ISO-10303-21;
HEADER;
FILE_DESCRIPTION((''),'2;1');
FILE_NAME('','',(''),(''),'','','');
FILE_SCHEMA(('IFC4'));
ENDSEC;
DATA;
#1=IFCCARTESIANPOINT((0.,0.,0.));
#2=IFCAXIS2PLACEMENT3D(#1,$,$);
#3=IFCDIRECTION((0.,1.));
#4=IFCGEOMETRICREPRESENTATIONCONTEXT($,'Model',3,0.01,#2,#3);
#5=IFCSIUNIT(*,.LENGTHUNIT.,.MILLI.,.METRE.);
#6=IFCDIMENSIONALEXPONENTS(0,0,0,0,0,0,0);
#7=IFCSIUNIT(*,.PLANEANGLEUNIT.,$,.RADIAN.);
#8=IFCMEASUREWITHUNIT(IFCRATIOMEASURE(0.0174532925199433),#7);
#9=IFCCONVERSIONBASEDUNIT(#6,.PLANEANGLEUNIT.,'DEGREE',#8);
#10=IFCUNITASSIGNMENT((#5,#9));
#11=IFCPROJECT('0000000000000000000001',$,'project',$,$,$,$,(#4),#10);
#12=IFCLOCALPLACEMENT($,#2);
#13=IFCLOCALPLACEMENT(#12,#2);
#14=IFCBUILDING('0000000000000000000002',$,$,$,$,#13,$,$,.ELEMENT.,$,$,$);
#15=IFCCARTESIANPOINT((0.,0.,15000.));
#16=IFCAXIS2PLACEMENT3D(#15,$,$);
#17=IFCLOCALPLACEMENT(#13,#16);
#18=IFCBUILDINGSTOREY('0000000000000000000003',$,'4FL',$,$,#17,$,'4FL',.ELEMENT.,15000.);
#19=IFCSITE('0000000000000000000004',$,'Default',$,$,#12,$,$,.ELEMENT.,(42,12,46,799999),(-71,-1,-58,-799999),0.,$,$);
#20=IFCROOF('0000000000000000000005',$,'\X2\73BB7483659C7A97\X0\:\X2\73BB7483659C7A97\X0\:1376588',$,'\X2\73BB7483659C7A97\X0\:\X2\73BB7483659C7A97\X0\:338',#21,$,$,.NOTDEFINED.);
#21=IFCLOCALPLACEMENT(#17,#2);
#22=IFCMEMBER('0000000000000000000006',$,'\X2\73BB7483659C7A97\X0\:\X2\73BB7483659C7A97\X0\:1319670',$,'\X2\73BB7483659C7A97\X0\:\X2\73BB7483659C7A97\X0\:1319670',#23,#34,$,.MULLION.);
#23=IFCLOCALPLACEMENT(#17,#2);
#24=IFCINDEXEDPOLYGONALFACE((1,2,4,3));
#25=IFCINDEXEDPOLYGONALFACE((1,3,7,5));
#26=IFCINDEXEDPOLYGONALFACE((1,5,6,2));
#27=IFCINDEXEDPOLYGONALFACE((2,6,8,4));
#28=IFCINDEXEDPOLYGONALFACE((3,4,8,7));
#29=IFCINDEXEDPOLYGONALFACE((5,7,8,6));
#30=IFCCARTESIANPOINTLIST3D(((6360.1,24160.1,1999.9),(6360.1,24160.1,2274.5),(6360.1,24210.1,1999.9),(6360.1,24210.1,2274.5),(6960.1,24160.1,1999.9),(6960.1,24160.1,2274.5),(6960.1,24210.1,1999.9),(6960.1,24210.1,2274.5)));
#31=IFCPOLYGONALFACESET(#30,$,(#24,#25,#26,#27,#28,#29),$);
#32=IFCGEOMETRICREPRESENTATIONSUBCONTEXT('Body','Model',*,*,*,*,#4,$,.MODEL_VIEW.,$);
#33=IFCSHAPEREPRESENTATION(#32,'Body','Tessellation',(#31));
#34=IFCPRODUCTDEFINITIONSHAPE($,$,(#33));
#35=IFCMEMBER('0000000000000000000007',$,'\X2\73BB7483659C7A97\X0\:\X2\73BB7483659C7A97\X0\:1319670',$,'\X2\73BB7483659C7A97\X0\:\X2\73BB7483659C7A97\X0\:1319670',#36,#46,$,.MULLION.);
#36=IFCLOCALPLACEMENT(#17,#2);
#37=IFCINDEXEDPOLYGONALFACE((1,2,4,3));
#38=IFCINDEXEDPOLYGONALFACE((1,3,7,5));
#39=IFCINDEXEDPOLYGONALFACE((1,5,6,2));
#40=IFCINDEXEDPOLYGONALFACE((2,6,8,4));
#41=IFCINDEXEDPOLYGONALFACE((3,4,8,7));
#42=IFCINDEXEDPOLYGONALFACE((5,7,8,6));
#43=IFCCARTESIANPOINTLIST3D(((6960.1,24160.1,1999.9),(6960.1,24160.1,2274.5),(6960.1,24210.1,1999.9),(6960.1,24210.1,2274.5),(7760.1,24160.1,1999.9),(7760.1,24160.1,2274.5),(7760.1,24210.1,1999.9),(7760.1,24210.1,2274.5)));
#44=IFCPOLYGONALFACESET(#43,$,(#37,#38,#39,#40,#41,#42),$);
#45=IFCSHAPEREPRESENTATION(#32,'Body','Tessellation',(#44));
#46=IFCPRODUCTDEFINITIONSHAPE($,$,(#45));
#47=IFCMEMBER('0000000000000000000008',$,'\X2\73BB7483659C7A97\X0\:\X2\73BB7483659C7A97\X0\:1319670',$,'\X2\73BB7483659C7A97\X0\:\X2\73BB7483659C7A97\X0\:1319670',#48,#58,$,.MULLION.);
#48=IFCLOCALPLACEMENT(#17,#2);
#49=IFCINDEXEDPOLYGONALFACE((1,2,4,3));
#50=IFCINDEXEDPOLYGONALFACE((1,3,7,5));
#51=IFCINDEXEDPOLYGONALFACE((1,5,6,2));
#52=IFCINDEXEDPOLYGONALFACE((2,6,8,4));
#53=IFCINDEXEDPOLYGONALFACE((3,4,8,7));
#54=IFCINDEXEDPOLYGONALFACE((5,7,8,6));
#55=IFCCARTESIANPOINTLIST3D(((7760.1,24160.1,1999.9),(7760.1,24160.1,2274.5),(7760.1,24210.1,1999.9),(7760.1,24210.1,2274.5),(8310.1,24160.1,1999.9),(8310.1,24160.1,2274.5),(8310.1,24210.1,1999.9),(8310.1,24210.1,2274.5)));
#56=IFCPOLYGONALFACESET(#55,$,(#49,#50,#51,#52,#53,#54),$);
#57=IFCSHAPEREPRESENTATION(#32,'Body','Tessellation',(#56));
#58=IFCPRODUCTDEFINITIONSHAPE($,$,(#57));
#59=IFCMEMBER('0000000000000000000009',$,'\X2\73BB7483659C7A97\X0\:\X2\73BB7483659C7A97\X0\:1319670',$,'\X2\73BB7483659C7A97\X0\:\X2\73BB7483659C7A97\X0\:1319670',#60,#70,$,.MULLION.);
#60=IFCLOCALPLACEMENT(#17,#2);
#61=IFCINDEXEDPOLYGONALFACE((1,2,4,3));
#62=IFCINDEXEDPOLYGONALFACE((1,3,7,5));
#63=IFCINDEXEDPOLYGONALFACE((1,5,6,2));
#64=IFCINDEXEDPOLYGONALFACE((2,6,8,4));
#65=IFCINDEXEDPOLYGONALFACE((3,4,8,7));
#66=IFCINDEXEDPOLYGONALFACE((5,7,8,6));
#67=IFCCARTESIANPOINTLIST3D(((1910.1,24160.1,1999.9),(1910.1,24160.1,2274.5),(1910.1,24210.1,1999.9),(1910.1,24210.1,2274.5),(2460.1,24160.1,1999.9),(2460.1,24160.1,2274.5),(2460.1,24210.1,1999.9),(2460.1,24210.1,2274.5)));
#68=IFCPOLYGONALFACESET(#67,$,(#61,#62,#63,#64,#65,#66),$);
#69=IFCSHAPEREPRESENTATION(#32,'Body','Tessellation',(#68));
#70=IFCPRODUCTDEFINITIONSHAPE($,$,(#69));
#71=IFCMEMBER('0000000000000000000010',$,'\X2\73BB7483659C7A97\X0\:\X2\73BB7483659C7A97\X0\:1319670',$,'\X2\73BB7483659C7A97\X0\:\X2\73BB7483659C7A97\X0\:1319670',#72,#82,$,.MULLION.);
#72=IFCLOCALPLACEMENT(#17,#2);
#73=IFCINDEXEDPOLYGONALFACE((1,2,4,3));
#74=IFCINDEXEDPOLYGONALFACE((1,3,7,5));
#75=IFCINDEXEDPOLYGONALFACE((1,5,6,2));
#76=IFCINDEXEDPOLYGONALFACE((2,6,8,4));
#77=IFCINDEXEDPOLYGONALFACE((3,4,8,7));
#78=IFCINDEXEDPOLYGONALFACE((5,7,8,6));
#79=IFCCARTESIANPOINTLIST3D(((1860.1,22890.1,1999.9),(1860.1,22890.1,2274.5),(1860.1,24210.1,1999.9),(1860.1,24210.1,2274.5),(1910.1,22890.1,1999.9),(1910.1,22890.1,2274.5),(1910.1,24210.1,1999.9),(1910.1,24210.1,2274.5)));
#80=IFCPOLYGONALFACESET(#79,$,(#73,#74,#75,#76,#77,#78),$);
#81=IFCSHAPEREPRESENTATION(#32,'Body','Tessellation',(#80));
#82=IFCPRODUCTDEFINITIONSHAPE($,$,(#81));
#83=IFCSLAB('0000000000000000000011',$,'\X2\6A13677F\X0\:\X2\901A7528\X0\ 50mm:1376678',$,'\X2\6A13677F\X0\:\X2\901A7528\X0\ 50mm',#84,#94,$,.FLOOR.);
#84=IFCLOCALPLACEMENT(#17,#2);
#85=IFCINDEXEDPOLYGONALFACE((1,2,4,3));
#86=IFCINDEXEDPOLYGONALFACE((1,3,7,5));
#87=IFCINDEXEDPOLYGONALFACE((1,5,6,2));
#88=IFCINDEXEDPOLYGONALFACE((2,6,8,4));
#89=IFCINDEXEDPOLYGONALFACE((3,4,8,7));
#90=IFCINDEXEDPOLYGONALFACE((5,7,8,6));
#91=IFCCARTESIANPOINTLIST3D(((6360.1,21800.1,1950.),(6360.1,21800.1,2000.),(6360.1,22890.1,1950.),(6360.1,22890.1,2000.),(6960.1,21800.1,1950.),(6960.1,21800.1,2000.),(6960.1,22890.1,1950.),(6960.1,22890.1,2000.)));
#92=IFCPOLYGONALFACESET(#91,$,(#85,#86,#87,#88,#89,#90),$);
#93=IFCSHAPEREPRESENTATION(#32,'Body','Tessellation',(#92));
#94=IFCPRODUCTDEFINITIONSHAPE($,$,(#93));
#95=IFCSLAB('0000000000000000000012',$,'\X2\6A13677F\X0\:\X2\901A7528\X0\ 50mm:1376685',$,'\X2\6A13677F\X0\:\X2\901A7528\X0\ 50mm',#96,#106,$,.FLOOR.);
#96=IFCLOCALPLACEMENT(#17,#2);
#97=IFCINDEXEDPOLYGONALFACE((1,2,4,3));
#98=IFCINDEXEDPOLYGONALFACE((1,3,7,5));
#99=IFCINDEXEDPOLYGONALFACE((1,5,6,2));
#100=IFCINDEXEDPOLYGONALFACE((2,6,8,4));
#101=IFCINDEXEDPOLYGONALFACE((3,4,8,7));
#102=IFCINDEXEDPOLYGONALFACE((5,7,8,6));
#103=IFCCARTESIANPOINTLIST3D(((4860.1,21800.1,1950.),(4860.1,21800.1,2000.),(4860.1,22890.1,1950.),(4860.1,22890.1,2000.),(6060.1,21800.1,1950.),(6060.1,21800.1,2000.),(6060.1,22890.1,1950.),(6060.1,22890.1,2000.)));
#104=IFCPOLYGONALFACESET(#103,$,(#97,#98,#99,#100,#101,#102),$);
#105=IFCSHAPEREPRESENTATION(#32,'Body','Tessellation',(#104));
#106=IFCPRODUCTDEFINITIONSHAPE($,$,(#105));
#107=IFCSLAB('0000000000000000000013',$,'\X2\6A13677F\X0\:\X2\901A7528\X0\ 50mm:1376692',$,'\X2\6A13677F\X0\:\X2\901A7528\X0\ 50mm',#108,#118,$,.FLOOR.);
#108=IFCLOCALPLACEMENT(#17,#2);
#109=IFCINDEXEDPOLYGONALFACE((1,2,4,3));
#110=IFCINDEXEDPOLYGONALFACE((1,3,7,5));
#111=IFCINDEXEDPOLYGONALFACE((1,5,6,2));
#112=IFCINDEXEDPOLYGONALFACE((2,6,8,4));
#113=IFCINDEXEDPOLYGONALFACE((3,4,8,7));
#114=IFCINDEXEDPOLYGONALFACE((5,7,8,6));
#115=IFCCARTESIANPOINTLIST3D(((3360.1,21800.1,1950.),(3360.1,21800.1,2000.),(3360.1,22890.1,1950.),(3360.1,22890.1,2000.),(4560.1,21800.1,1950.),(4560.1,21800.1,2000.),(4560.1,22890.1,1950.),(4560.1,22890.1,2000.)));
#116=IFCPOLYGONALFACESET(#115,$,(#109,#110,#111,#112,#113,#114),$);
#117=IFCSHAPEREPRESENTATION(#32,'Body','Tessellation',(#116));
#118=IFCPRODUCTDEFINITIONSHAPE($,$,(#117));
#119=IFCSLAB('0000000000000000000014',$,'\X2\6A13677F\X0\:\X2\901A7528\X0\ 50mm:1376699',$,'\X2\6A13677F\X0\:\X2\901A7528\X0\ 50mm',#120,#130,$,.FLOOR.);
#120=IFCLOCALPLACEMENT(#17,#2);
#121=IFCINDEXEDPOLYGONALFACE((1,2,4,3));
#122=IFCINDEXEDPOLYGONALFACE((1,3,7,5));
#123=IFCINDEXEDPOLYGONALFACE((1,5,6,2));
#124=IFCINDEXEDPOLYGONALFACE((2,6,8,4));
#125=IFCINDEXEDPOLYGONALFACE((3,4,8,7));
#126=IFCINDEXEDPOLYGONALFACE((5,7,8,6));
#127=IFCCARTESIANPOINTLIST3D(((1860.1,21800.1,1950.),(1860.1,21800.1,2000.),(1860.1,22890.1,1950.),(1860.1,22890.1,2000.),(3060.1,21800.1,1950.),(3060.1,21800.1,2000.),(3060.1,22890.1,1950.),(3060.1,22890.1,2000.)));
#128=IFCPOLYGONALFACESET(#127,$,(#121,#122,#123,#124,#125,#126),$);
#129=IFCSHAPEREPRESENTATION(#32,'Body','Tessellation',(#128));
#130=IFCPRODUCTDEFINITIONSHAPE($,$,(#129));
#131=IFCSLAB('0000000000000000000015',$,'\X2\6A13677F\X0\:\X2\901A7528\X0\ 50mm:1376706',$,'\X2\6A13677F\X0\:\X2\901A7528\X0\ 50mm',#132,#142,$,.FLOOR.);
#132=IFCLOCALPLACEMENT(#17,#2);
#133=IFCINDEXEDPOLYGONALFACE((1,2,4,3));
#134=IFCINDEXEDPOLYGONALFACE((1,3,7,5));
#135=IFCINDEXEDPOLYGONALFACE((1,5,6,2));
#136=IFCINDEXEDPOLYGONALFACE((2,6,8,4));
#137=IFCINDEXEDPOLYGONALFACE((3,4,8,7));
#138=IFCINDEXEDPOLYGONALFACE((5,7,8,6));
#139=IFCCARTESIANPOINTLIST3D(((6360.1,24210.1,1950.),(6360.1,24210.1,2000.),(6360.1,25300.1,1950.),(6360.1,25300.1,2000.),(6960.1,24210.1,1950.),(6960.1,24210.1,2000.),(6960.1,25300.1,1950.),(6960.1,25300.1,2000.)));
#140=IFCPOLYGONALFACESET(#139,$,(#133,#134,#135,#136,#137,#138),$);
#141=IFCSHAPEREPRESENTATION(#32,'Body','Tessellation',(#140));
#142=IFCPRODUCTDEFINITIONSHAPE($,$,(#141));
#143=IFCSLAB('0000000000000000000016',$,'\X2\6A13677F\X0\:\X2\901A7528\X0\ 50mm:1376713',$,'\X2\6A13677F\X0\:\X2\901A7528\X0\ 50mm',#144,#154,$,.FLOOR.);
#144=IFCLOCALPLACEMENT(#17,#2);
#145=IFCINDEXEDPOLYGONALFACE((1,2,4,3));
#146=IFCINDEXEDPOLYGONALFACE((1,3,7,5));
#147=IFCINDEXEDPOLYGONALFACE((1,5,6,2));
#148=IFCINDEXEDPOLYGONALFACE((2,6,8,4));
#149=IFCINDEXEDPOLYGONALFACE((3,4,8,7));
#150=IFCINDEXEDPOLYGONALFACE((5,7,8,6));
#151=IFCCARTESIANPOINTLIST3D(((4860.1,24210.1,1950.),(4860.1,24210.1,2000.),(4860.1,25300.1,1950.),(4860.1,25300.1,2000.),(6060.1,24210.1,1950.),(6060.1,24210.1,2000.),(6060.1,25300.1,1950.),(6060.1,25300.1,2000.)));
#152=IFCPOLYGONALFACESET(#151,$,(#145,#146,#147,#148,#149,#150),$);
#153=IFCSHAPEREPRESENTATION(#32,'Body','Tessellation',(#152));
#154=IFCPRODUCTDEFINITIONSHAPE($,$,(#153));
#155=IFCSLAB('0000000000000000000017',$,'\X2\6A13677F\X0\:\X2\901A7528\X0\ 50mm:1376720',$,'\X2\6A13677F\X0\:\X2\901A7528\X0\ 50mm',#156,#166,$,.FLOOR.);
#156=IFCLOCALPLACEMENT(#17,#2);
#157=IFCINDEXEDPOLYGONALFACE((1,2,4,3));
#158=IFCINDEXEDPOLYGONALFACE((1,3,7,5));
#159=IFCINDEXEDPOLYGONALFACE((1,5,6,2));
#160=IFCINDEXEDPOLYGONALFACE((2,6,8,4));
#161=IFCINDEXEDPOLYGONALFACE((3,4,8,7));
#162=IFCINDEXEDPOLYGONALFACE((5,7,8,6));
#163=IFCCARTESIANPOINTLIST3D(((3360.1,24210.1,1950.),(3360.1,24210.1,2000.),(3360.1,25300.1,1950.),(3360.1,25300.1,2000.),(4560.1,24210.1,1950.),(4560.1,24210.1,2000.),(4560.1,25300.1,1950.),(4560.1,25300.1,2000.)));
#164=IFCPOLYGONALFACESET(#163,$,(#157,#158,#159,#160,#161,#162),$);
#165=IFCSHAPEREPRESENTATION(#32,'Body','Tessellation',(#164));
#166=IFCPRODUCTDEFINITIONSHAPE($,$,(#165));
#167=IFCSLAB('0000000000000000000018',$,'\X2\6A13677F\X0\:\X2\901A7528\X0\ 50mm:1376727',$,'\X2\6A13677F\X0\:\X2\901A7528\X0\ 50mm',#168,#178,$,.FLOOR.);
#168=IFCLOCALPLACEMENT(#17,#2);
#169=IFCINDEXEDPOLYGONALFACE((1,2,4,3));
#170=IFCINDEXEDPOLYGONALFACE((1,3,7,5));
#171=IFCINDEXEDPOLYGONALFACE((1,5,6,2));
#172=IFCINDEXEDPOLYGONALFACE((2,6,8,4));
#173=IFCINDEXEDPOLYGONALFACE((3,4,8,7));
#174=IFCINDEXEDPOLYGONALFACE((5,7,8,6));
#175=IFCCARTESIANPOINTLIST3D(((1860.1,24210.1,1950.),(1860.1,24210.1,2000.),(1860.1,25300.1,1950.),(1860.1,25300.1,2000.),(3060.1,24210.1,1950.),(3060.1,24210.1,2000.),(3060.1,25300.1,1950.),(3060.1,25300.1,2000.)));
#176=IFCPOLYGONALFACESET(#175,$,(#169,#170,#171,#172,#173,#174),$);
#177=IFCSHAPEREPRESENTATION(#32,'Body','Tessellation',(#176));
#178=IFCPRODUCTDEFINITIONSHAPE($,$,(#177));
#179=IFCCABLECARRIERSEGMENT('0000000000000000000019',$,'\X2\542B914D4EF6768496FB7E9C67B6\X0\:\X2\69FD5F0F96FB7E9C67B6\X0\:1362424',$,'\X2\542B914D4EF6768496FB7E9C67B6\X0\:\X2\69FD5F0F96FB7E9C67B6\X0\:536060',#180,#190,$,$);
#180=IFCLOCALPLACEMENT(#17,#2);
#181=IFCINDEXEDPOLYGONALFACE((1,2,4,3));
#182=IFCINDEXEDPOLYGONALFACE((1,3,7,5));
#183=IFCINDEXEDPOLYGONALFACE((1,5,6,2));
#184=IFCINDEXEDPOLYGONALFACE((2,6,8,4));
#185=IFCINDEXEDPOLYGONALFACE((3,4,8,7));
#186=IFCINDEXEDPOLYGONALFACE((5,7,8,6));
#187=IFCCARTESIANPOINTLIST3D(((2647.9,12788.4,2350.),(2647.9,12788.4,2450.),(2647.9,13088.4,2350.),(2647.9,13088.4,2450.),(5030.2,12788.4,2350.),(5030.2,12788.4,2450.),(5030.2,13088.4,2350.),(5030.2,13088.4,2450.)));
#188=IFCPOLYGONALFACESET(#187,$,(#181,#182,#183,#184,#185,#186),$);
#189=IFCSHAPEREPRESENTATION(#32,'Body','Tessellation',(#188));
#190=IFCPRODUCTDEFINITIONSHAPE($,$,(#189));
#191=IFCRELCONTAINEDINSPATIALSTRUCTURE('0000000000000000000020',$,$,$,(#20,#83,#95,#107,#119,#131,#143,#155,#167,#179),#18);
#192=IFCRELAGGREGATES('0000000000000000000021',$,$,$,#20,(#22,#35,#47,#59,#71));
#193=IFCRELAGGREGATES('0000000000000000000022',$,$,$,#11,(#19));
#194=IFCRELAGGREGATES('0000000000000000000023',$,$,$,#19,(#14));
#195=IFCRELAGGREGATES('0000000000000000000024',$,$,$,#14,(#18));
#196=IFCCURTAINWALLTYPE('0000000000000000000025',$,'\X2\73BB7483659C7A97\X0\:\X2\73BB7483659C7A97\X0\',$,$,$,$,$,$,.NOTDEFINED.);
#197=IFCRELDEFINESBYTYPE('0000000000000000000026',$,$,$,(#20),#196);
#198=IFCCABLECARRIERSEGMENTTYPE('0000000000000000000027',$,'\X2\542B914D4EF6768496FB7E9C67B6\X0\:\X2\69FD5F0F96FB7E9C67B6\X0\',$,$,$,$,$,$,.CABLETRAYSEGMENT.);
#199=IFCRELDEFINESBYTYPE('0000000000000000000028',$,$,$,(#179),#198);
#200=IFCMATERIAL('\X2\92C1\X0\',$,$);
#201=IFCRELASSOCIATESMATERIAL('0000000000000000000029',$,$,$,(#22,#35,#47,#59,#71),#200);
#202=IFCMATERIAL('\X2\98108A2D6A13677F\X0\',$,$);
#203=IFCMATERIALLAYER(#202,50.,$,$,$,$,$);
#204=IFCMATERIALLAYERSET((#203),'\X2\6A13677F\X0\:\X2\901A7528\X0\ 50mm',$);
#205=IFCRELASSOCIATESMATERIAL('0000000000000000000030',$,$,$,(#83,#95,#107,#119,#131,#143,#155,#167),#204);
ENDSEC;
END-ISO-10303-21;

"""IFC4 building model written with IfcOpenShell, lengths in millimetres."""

from ifc_helpers import new_model, entity, si_unit, converted_unit, direction, frame, frame_2d, origin, place, context, subcontext, project, spatial, rectangle, extrude, material, layer, layer_set, layer_usage, type_object, element, aggregate, save


model = new_model("IFC4")

# Units and contexts
model_context = context("Model", 3, precision=0.01, world=origin(), true_north=direction((0.0, 1.0)))
body_context = subcontext(model_context, "Body", "Model", "MODEL_VIEW")
ifc_project = project(units=[si_unit("LENGTHUNIT", "METRE", prefix="MILLI"), converted_unit("PLANEANGLEUNIT", "DEGREE", entity("IfcRatioMeasure", 0.0174532925199433), si_unit("PLANEANGLEUNIT", "RADIAN"), dimensions=[0, 0, 0, 0, 0, 0, 0])], contexts=[model_context])

# Site, building, storey
site_placement = place(None, origin())
site = spatial("IfcSite", under=ifc_project, at=site_placement, Name="Default", CompositionType="ELEMENT", RefLatitude=(42, 12, 46, 799999), RefLongitude=(-71, -1, -58, -799999), RefElevation=0.0)
building_placement = place(site_placement, origin())
building = spatial("IfcBuilding", under=site, at=building_placement, CompositionType="ELEMENT")
storey_placement = place(building_placement, frame((0.0, 0.0, 15000.0)))
storey = spatial("IfcBuildingStorey", under=building, at=storey_placement, Name="4FL", LongName="4FL", CompositionType="ELEMENT", Elevation=15000.0)

# Roof, members
curtain_wall_type = type_object("IfcCurtainWallType", Name="玻璃斜窗:玻璃斜窗", PredefinedType="NOTDEFINED")
roof_placement = place(storey_placement, frame((0.0, 0.0, -15000.0)))
roof = element("IfcRoof", 1, at=roof_placement, inside=storey, type_object=curtain_wall_type, Name="玻璃斜窗:玻璃斜窗:1376588", ObjectType="玻璃斜窗:玻璃斜窗:338", PredefinedType="NOTDEFINED")
ifc_material_1 = material(Name="鋁")
member_1_placement = place(roof_placement, frame((0.0, 0.0, 15000.0)))
member_1 = element("IfcMember", 2, at=member_1_placement, material=ifc_material_1, Name="玻璃斜窗:玻璃斜窗:1319670", ObjectType="玻璃斜窗:玻璃斜窗:1319670", PredefinedType="MULLION", context=body_context, shape_type="SweptSolid", body=[
    extrude(rectangle(XDim=274.5, YDim=50.0, at=frame_2d((0.0, 0.0), x_axis=(1.0, 0.0))), frame((6360.1, 24185.1, 2137.2), z_axis=(1.0, 0.0, 0.0), x_axis=(0.0, 0.0, -1.0)), (0.0, 0.0, 1.0), 600.0),
])
member_2_placement = place(roof_placement, frame((0.0, 0.0, 15000.0)))
member_2 = element("IfcMember", 3, at=member_2_placement, material=ifc_material_1, Name="玻璃斜窗:玻璃斜窗:1319670", ObjectType="玻璃斜窗:玻璃斜窗:1319670", PredefinedType="MULLION", context=body_context, shape_type="SweptSolid", body=[
    extrude(rectangle(XDim=274.5, YDim=50.0, at=frame_2d((0.0, 0.0), x_axis=(1.0, 0.0))), frame((6960.1, 24185.1, 2137.2), z_axis=(1.0, 0.0, 0.0), x_axis=(0.0, 0.0, -1.0)), (0.0, 0.0, 1.0), 800.0),
])
member_3_placement = place(roof_placement, frame((0.0, 0.0, 15000.0)))
member_3 = element("IfcMember", 4, at=member_3_placement, material=ifc_material_1, Name="玻璃斜窗:玻璃斜窗:1319670", ObjectType="玻璃斜窗:玻璃斜窗:1319670", PredefinedType="MULLION", context=body_context, shape_type="SweptSolid", body=[
    extrude(rectangle(XDim=274.5, YDim=50.0, at=frame_2d((0.0, 0.0), x_axis=(1.0, 0.0))), frame((7760.1, 24185.1, 2137.2), z_axis=(1.0, 0.0, 0.0), x_axis=(0.0, 0.0, -1.0)), (0.0, 0.0, 1.0), 550.0),
])
member_4_placement = place(roof_placement, frame((0.0, 0.0, 15000.0)))
member_4 = element("IfcMember", 5, at=member_4_placement, material=ifc_material_1, Name="玻璃斜窗:玻璃斜窗:1319670", ObjectType="玻璃斜窗:玻璃斜窗:1319670", PredefinedType="MULLION", context=body_context, shape_type="SweptSolid", body=[
    extrude(rectangle(XDim=274.5, YDim=50.0, at=frame_2d((0.0, 0.0), x_axis=(1.0, 0.0))), frame((1910.1, 24185.1, 2137.2), z_axis=(1.0, 0.0, 0.0), x_axis=(0.0, 0.0, -1.0)), (0.0, 0.0, 1.0), 550.0),
])
member_5_placement = place(roof_placement, frame((0.0, 0.0, 15000.0)))
member_5 = element("IfcMember", 6, at=member_5_placement, material=ifc_material_1, Name="玻璃斜窗:玻璃斜窗:1319670", ObjectType="玻璃斜窗:玻璃斜窗:1319670", PredefinedType="MULLION", context=body_context, shape_type="SweptSolid", body=[
    extrude(rectangle(XDim=274.5, YDim=50.0, at=frame_2d((0.0, 0.0), x_axis=(1.0, 0.0))), frame((1885.1, 22890.1, 2137.2), z_axis=(0.0, 1.0, 0.0), x_axis=(0.0, 0.0, -1.0)), (0.0, 0.0, 1.0), 1320.0),
])
aggregate(roof, [member_1, member_2, member_3, member_4, member_5])

# Slabs
ifc_material_2 = material(Name="預設樓板")
ifc_layer = layer(ifc_material_2, 50.0)
ifc_layer_set = layer_set([ifc_layer], Name="樓板:通用 50mm")
ifc_layer_usage_1 = layer_usage(ifc_layer_set, "AXIS3", "POSITIVE", 0.0)
slab_1_placement = place(storey_placement, origin())
element("IfcSlab", 7, at=slab_1_placement, inside=storey, material=ifc_layer_usage_1, Name="樓板:通用 50mm:1376678", ObjectType="樓板:通用 50mm", PredefinedType="FLOOR", context=body_context, shape_type="SweptSolid", body=[
    extrude(rectangle(XDim=1090.0, YDim=600.0, at=frame_2d((0.0, 0.0), x_axis=(1.0, 0.0))), frame((6660.1, 22345.1, 2000.0), z_axis=(0.0, 0.0, -1.0), x_axis=(0.0, 1.0, 0.0)), (0.0, 0.0, 1.0), 50.0),
])
ifc_layer_usage_2 = layer_usage(ifc_layer_set, "AXIS3", "POSITIVE", 0.0)
slab_2_placement = place(storey_placement, origin())
element("IfcSlab", 8, at=slab_2_placement, inside=storey, material=ifc_layer_usage_2, Name="樓板:通用 50mm:1376685", ObjectType="樓板:通用 50mm", PredefinedType="FLOOR", context=body_context, shape_type="SweptSolid", body=[
    extrude(rectangle(XDim=1090.0, YDim=1200.0, at=frame_2d((0.0, 0.0), x_axis=(1.0, 0.0))), frame((5460.1, 22345.1, 2000.0), z_axis=(0.0, 0.0, -1.0), x_axis=(0.0, 1.0, 0.0)), (0.0, 0.0, 1.0), 50.0),
])
ifc_layer_usage_3 = layer_usage(ifc_layer_set, "AXIS3", "POSITIVE", 0.0)
slab_3_placement = place(storey_placement, origin())
element("IfcSlab", 9, at=slab_3_placement, inside=storey, material=ifc_layer_usage_3, Name="樓板:通用 50mm:1376692", ObjectType="樓板:通用 50mm", PredefinedType="FLOOR", context=body_context, shape_type="SweptSolid", body=[
    extrude(rectangle(XDim=1090.0, YDim=1200.0, at=frame_2d((0.0, 0.0), x_axis=(1.0, 0.0))), frame((3960.1, 22345.1, 2000.0), z_axis=(0.0, 0.0, -1.0), x_axis=(0.0, 1.0, 0.0)), (0.0, 0.0, 1.0), 50.0),
])
ifc_layer_usage_4 = layer_usage(ifc_layer_set, "AXIS3", "POSITIVE", 0.0)
slab_4_placement = place(storey_placement, origin())
element("IfcSlab", 10, at=slab_4_placement, inside=storey, material=ifc_layer_usage_4, Name="樓板:通用 50mm:1376699", ObjectType="樓板:通用 50mm", PredefinedType="FLOOR", context=body_context, shape_type="SweptSolid", body=[
    extrude(rectangle(XDim=1090.0, YDim=1200.0, at=frame_2d((0.0, 0.0), x_axis=(1.0, 0.0))), frame((2460.1, 22345.1, 2000.0), z_axis=(0.0, 0.0, -1.0), x_axis=(0.0, 1.0, 0.0)), (0.0, 0.0, 1.0), 50.0),
])
ifc_layer_usage_5 = layer_usage(ifc_layer_set, "AXIS3", "POSITIVE", 0.0)
slab_5_placement = place(storey_placement, origin())
element("IfcSlab", 11, at=slab_5_placement, inside=storey, material=ifc_layer_usage_5, Name="樓板:通用 50mm:1376706", ObjectType="樓板:通用 50mm", PredefinedType="FLOOR", context=body_context, shape_type="SweptSolid", body=[
    extrude(rectangle(XDim=1090.0, YDim=600.0, at=frame_2d((0.0, 0.0), x_axis=(1.0, 0.0))), frame((6660.1, 24755.1, 2000.0), z_axis=(0.0, 0.0, -1.0), x_axis=(0.0, 1.0, 0.0)), (0.0, 0.0, 1.0), 50.0),
])
ifc_layer_usage_6 = layer_usage(ifc_layer_set, "AXIS3", "POSITIVE", 0.0)
slab_6_placement = place(storey_placement, origin())
element("IfcSlab", 12, at=slab_6_placement, inside=storey, material=ifc_layer_usage_6, Name="樓板:通用 50mm:1376713", ObjectType="樓板:通用 50mm", PredefinedType="FLOOR", context=body_context, shape_type="SweptSolid", body=[
    extrude(rectangle(XDim=1090.0, YDim=1200.0, at=frame_2d((0.0, 0.0), x_axis=(1.0, 0.0))), frame((5460.1, 24755.1, 2000.0), z_axis=(0.0, 0.0, -1.0), x_axis=(0.0, 1.0, 0.0)), (0.0, 0.0, 1.0), 50.0),
])
ifc_layer_usage_7 = layer_usage(ifc_layer_set, "AXIS3", "POSITIVE", 0.0)
slab_7_placement = place(storey_placement, origin())
element("IfcSlab", 13, at=slab_7_placement, inside=storey, material=ifc_layer_usage_7, Name="樓板:通用 50mm:1376720", ObjectType="樓板:通用 50mm", PredefinedType="FLOOR", context=body_context, shape_type="SweptSolid", body=[
    extrude(rectangle(XDim=1090.0, YDim=1200.0, at=frame_2d((0.0, 0.0), x_axis=(1.0, 0.0))), frame((3960.1, 24755.1, 2000.0), z_axis=(0.0, 0.0, -1.0), x_axis=(0.0, 1.0, 0.0)), (0.0, 0.0, 1.0), 50.0),
])
ifc_layer_usage_8 = layer_usage(ifc_layer_set, "AXIS3", "POSITIVE", 0.0)
slab_8_placement = place(storey_placement, origin())
element("IfcSlab", 14, at=slab_8_placement, inside=storey, material=ifc_layer_usage_8, Name="樓板:通用 50mm:1376727", ObjectType="樓板:通用 50mm", PredefinedType="FLOOR", context=body_context, shape_type="SweptSolid", body=[
    extrude(rectangle(XDim=1090.0, YDim=1200.0, at=frame_2d((0.0, 0.0), x_axis=(1.0, 0.0))), frame((2460.1, 24755.1, 2000.0), z_axis=(0.0, 0.0, -1.0), x_axis=(0.0, 1.0, 0.0)), (0.0, 0.0, 1.0), 50.0),
])

# Cable carrier segment
cable_carrier_segment_type_1 = type_object("IfcCableCarrierSegmentType", Name="含配件的電纜架:槽式電纜架", PredefinedType="CABLETRAYSEGMENT")
cable_carrier_segment_1_placement = place(storey_placement, frame((2647.9, 12788.4, 2350.0)))
element("IfcCableCarrierSegment", 15, at=cable_carrier_segment_1_placement, inside=storey, type_object=cable_carrier_segment_type_1, Name="含配件的電纜架:槽式電纜架:1362424", ObjectType="含配件的電纜架:槽式電纜架:536060", context=body_context, shape_type="SweptSolid", body=[
    extrude(rectangle(XDim=2382.4, YDim=300.0, at=frame_2d((0.0, 0.0), x_axis=(1.0, 0.0))), frame((1191.2, 150.0, 0.0), z_axis=(0.0, 0.0, 1.0), x_axis=(-1.0, 0.0, 0.0)), (0.0, 0.0, 1.0), 100.0),
])

save(model, "model.ifc")
